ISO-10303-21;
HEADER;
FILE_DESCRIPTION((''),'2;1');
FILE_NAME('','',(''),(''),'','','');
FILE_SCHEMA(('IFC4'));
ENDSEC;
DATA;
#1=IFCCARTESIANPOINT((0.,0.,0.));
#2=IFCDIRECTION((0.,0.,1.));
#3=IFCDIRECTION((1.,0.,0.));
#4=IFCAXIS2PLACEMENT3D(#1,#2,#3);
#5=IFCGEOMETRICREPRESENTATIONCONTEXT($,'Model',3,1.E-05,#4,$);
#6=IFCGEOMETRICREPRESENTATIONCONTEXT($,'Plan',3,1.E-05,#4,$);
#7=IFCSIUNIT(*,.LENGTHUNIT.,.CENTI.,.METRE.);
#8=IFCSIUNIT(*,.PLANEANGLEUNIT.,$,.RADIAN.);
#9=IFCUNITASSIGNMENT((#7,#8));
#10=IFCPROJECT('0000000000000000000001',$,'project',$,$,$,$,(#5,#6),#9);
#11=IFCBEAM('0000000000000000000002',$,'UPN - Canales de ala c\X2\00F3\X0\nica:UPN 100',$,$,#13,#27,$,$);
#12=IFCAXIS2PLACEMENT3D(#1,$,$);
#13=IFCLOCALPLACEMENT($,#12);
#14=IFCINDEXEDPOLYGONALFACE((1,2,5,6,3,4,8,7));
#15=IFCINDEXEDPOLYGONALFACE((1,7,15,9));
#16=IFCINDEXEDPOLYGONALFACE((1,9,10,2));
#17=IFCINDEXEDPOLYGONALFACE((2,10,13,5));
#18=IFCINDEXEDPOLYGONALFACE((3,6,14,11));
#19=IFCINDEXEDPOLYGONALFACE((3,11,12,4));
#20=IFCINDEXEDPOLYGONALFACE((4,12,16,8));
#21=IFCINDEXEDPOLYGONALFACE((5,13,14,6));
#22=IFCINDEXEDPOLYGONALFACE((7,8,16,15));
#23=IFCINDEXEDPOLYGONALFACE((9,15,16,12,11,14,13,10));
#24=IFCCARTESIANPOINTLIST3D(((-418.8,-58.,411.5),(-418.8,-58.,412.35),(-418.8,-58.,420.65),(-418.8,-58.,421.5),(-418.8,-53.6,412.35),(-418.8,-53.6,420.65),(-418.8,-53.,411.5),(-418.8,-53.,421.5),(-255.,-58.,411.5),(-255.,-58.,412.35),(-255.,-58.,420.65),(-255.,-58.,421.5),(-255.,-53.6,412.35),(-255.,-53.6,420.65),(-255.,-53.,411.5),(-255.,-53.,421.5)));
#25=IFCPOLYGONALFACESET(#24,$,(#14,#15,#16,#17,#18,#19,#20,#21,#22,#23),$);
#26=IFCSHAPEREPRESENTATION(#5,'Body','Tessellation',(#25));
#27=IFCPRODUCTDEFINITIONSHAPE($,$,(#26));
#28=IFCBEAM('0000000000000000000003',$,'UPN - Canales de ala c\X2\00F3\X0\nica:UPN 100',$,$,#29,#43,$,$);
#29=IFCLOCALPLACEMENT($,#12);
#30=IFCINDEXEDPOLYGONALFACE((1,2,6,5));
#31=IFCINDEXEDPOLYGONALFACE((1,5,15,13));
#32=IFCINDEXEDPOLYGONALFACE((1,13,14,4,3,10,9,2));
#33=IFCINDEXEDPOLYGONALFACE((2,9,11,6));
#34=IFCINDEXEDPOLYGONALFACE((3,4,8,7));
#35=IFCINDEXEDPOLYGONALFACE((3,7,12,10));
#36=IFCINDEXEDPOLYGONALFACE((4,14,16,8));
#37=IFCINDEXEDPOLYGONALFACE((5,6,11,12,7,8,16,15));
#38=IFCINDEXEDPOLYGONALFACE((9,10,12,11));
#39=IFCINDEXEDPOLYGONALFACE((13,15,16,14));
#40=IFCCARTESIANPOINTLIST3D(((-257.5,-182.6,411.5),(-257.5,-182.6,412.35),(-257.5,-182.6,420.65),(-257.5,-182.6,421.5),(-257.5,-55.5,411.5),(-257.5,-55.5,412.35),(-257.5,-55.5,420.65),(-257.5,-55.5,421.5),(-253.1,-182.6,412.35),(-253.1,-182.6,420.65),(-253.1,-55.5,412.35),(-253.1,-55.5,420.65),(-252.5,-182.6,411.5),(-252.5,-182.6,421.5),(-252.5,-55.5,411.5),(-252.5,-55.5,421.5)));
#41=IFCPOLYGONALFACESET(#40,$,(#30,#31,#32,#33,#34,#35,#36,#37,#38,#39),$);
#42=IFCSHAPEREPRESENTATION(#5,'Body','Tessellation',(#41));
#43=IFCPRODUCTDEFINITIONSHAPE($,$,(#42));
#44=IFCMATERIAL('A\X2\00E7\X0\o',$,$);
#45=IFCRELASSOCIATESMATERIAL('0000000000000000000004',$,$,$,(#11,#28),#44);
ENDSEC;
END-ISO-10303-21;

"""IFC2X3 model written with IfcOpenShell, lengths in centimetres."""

from ifc_helpers import new_model, si_unit, frame, origin_with_axes, origin_2d_with_axis, place, context, project, u_section, extrude, material, element, save


model = new_model("IFC2X3")

# Units and contexts
model_context = context("Model", 3, precision=1e-05, world=origin_with_axes())
plan_context = context("Plan", 3, precision=1e-05, world=origin_with_axes())
ifc_project = project(units=[si_unit("LENGTHUNIT", "METRE", prefix="CENTI"), si_unit("PLANEANGLEUNIT", "RADIAN")], contexts=[model_context, plan_context])

# Shared definitions
ifc_material = material(Name="Aço")

# Beams
beam_1_placement = place(None, frame((-255.0, -55.5, 416.5), z_axis=(-1.0, 0.0, 0.0), x_axis=(0.0, -1.0, 0.0)))
element("IfcBeam", 1, at=beam_1_placement, material=ifc_material, Name="UPN - Canales de ala cónica:UPN 100", context=model_context, shape_type="SweptSolid", body=[
    extrude(u_section(Depth=10.0, FlangeWidth=5.0, WebThickness=0.6, FlangeThickness=0.85, FilletRadius=0.0, EdgeRadius=0.0, FlangeSlope=0.0, CentreOfGravityInX=0.0, at=origin_2d_with_axis()), origin_with_axes(), (0.0, 0.0, 1.0), 163.8),
])
beam_2_placement = place(None, frame((-255.0, -182.6, 416.5), z_axis=(0.0, 1.0, 0.0), x_axis=(-1.0, 0.0, 0.0)))
element("IfcBeam", 2, at=beam_2_placement, material=ifc_material, Name="UPN - Canales de ala cónica:UPN 100", context=model_context, shape_type="SweptSolid", body=[
    extrude(u_section(Depth=10.0, FlangeWidth=5.0, WebThickness=0.6, FlangeThickness=0.85, FilletRadius=0.0, EdgeRadius=0.0, FlangeSlope=0.0, CentreOfGravityInX=0.0, at=origin_2d_with_axis()), origin_with_axes(), (0.0, 0.0, 1.0), 127.1),
])

save(model, "model.ifc")
